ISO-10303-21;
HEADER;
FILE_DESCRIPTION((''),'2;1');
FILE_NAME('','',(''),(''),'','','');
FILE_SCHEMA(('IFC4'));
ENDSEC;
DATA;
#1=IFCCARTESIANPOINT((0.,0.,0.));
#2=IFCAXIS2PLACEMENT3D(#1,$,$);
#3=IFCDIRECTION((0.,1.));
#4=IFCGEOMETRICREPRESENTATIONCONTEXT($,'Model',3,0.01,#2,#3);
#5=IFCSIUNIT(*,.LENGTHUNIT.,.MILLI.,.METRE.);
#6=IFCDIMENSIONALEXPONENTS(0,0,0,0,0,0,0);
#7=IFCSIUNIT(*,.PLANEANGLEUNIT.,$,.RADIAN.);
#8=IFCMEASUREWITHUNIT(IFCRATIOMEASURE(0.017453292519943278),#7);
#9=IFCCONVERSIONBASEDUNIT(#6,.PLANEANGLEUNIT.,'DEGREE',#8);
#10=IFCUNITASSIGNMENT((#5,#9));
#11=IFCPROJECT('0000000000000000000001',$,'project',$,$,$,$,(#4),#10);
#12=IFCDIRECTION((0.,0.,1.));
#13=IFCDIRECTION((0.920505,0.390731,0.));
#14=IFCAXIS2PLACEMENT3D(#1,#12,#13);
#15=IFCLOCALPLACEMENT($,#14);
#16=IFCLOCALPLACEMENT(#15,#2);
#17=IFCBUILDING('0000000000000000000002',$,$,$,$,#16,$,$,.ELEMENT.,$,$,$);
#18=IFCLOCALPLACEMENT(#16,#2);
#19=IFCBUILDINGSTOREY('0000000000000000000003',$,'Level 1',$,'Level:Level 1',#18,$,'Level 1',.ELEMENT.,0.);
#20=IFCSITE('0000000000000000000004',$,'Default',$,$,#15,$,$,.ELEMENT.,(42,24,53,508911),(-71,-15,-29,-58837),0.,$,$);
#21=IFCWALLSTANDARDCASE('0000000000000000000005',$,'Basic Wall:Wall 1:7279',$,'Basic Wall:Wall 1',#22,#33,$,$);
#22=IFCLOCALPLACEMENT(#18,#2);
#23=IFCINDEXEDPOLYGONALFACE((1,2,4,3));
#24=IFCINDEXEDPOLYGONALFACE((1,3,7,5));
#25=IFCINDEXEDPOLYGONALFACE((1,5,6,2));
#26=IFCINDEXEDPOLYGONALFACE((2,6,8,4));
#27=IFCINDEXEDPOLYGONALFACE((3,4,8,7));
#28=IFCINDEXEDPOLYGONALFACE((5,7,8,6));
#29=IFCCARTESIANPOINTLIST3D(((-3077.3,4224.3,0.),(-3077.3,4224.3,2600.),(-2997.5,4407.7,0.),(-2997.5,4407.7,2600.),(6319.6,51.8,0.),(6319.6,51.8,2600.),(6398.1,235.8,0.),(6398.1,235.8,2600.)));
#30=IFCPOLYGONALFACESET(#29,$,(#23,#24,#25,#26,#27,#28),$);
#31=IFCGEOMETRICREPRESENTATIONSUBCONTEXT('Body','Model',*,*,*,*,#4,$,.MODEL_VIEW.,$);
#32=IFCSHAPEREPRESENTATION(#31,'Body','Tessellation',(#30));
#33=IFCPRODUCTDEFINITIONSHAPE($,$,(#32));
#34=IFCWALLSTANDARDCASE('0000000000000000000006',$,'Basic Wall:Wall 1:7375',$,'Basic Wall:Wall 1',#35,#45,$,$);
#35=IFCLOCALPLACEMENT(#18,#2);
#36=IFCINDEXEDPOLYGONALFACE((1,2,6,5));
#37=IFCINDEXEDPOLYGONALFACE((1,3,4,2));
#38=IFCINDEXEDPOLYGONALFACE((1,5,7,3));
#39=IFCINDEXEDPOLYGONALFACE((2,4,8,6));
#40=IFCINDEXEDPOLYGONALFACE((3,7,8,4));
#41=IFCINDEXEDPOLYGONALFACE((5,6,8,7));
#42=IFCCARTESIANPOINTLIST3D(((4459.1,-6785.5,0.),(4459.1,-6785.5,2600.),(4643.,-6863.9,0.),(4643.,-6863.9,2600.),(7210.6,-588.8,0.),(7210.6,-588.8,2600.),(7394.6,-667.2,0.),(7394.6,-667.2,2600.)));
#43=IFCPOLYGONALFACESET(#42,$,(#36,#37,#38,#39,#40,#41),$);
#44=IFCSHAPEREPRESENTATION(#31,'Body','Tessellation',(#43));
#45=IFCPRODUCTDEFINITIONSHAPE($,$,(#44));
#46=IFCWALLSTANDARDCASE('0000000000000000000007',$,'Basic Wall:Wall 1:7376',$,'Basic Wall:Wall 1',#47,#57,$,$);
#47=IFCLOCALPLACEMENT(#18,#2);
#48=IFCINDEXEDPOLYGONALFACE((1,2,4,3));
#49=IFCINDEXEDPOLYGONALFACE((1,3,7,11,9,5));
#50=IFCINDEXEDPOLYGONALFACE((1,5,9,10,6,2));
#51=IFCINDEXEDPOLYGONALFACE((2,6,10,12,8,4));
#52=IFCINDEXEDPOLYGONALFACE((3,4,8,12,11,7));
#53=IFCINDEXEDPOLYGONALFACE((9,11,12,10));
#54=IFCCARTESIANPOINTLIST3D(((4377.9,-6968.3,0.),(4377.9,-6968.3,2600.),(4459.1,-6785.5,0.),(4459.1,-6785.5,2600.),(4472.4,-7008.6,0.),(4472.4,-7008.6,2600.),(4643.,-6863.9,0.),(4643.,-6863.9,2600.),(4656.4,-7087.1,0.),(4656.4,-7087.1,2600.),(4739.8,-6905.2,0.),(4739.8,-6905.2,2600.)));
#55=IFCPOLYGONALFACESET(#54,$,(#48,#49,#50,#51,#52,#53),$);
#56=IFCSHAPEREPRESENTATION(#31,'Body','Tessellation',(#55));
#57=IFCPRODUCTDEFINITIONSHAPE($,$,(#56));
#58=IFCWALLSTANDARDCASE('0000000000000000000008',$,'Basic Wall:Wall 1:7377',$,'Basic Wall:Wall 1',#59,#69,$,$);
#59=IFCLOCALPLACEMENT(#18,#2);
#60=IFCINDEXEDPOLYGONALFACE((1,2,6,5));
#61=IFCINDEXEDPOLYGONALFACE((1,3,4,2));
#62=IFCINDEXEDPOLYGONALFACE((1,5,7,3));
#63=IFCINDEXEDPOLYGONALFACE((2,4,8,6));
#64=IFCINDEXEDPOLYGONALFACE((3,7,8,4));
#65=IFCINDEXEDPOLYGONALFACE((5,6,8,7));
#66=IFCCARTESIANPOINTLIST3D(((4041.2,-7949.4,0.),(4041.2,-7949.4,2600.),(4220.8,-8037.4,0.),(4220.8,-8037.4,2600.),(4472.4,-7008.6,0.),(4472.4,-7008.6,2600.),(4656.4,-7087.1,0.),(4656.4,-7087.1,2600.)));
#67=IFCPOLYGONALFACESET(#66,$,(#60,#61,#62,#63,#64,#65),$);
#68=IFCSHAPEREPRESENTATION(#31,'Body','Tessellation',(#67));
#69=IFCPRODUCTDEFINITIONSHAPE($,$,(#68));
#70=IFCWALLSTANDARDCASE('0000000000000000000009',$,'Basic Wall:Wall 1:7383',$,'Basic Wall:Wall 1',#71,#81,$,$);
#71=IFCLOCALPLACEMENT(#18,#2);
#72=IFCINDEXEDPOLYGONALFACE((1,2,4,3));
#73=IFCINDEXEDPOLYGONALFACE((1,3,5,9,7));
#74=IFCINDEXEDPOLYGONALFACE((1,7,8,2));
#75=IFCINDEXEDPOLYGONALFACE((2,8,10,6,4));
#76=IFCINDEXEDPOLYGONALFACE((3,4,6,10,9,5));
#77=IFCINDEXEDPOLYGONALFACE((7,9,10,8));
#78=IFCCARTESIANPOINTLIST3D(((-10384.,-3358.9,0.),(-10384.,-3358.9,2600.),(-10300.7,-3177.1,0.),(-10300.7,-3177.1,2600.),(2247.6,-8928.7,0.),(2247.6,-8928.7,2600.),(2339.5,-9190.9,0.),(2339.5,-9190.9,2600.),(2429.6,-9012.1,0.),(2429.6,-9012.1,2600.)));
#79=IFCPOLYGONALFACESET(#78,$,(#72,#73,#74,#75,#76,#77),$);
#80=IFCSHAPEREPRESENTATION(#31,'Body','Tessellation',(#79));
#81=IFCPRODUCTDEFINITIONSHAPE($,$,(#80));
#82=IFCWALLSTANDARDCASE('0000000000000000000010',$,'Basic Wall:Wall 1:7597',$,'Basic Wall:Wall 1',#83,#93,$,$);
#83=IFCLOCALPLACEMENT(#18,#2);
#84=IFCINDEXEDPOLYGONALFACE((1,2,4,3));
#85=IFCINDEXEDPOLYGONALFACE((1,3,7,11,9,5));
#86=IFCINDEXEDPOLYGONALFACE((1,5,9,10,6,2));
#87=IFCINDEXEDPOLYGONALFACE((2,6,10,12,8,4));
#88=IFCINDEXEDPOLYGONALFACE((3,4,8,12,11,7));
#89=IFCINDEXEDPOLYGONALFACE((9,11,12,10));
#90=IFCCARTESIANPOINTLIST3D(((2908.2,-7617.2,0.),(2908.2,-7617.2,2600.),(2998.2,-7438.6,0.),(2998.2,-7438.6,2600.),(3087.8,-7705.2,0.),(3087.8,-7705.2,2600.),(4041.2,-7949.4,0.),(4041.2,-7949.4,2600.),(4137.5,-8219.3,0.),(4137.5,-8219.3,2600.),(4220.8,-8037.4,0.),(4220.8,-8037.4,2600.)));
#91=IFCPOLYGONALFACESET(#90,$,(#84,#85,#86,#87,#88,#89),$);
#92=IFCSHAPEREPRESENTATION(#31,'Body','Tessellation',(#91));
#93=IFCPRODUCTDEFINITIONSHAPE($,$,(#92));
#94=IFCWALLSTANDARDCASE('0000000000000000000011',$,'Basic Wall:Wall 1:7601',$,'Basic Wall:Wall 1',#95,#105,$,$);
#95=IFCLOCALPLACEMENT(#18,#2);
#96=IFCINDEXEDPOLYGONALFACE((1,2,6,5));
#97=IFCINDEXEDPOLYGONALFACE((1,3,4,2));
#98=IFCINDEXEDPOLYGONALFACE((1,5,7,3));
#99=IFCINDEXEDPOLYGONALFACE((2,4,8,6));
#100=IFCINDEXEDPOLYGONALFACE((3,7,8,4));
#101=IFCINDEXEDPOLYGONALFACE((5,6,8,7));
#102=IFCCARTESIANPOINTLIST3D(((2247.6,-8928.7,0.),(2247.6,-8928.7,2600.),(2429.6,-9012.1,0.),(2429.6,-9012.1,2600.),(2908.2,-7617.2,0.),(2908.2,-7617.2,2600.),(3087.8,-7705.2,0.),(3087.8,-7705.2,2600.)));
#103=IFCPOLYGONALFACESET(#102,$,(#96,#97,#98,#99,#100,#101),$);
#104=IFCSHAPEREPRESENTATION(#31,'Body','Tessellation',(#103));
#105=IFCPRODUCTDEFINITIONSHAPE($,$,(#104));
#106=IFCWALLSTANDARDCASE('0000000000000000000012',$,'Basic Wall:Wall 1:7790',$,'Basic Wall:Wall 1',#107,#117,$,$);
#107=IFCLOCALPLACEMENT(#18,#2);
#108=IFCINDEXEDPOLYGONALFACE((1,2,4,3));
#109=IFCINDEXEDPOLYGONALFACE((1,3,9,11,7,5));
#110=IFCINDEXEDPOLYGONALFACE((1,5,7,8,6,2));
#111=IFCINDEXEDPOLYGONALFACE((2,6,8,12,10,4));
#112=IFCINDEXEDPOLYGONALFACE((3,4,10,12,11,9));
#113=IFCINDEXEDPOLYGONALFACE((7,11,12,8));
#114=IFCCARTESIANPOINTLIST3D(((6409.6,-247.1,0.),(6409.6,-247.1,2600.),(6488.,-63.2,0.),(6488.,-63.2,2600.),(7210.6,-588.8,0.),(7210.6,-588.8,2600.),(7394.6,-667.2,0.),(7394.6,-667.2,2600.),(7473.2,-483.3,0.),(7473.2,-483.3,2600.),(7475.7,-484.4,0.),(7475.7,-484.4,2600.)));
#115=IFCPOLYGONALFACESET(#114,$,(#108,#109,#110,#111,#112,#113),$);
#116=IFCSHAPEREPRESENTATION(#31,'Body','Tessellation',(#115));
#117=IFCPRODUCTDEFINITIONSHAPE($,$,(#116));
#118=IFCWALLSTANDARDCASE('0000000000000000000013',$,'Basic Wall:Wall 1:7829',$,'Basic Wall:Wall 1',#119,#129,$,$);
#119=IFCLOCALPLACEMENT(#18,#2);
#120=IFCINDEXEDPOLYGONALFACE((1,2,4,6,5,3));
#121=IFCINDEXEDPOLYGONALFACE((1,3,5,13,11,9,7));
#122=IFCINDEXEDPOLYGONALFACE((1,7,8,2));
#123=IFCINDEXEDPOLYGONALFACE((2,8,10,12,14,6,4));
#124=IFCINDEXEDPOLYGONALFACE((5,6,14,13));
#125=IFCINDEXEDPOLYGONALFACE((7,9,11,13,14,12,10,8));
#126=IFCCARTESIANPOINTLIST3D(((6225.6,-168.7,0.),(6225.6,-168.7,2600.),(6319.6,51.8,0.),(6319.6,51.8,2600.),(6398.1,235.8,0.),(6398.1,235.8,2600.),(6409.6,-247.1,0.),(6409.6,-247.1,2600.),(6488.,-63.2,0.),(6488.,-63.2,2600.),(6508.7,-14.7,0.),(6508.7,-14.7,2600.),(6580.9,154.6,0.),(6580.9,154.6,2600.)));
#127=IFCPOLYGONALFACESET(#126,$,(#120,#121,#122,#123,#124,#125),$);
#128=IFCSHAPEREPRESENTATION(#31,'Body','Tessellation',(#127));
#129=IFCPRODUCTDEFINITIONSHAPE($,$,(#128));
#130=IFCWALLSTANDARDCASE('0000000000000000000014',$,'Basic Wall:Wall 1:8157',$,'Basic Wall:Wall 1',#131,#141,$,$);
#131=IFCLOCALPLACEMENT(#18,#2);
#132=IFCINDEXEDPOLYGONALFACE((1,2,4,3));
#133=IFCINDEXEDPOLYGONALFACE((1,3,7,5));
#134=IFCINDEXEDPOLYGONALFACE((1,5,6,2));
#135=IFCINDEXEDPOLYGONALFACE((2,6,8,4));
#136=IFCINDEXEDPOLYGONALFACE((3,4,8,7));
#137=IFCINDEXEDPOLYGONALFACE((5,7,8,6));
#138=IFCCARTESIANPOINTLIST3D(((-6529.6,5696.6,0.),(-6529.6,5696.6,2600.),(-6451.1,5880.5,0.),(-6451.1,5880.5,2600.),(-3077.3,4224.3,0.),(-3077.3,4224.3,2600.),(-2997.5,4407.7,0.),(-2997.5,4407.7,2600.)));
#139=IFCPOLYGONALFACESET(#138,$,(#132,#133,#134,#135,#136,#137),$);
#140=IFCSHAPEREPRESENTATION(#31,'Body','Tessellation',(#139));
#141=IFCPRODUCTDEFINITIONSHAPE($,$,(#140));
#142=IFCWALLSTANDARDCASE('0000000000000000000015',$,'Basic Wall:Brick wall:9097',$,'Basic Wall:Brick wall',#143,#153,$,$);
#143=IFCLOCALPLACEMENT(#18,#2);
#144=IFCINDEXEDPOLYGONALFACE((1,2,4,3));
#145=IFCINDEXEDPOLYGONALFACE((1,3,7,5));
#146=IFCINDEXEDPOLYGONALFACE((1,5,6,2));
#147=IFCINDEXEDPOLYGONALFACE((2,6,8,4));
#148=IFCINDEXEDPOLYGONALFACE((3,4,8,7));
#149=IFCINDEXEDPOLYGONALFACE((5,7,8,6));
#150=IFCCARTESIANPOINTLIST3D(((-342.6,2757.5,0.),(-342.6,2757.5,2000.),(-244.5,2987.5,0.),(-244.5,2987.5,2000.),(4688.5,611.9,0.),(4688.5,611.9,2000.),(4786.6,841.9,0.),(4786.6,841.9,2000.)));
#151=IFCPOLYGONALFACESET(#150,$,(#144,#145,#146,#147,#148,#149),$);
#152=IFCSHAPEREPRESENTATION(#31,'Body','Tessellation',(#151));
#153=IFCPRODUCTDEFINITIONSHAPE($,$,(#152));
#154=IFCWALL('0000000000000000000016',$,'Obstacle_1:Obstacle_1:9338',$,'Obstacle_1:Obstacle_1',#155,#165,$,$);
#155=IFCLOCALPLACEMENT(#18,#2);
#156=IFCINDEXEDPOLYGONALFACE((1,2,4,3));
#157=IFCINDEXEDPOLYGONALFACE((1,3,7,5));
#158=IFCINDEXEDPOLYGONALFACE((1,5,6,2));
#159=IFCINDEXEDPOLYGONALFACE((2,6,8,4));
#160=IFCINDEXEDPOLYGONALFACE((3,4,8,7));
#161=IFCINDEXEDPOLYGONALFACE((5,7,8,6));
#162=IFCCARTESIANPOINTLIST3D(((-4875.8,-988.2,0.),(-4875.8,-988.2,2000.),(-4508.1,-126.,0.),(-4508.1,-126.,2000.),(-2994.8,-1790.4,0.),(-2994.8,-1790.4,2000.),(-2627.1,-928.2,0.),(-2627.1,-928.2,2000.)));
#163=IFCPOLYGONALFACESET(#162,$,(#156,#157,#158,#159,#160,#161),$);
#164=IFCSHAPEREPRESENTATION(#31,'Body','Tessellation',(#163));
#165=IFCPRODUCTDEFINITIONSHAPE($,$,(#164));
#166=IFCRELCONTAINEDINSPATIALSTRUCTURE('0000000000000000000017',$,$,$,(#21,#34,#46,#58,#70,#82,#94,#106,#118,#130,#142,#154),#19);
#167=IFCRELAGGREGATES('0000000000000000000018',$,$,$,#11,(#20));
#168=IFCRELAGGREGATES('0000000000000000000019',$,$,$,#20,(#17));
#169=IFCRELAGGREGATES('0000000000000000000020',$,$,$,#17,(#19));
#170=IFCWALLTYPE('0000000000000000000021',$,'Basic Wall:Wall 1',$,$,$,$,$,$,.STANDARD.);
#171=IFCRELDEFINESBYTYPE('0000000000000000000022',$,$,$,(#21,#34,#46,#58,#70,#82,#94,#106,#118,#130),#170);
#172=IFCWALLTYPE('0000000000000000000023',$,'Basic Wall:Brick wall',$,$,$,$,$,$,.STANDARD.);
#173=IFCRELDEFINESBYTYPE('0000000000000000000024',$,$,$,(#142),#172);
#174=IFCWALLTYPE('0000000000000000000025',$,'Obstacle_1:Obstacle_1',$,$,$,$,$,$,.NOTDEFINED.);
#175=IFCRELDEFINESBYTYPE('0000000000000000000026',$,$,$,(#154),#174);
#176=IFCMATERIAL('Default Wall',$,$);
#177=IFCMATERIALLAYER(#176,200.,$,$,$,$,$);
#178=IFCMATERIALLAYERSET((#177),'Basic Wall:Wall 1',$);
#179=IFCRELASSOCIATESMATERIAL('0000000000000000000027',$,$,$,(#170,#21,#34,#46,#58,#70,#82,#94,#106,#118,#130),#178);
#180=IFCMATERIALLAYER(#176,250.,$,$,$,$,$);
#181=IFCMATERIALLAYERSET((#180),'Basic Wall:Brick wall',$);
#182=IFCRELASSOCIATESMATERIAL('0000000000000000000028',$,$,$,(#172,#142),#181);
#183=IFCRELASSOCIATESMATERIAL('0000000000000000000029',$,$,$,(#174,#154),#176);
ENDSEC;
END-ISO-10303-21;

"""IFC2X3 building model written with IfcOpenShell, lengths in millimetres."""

from ifc_helpers import new_model, entity, si_unit, converted_unit, direction, frame, frame_2d, origin, place, context, subcontext, project, spatial, polyline, rectangle, outline, extrude, material, layer, layer_set, layer_usage, type_object, element, save


model = new_model("IFC2X3")

# Units and contexts
model_context = context("Model", 3, precision=0.01, world=origin(), true_north=direction((0.0, 1.0)))
body_context = subcontext(model_context, "Body", "Model", "MODEL_VIEW")
ifc_project = project(units=[si_unit("LENGTHUNIT", "METRE", prefix="MILLI"), converted_unit("PLANEANGLEUNIT", "DEGREE", entity("IfcRatioMeasure", 0.017453292519943278), si_unit("PLANEANGLEUNIT", "RADIAN"), dimensions=[0, 0, 0, 0, 0, 0, 0])], contexts=[model_context])

# Site, building, storey
site_placement = place(None, frame((0.0, 0.0, 0.0), z_axis=(0.0, 0.0, 1.0), x_axis=(0.920505, 0.390731, 0.0)))
site = spatial("IfcSite", under=ifc_project, at=site_placement, Name="Default", CompositionType="ELEMENT", RefLatitude=(42, 24, 53, 508911), RefLongitude=(-71, -15, -29, -58837), RefElevation=0.0)
building_placement = place(site_placement, origin())
building = spatial("IfcBuilding", under=site, at=building_placement, CompositionType="ELEMENT")
storey_placement = place(building_placement, origin())
storey = spatial("IfcBuildingStorey", under=building, at=storey_placement, Name="Level 1", ObjectType="Level:Level 1", LongName="Level 1", CompositionType="ELEMENT", Elevation=0.0)

# Walls
ifc_material_1 = material(Name="Default Wall")
ifc_layer_1 = layer(ifc_material_1, 200.0)
ifc_layer_set_1 = layer_set([ifc_layer_1], Name="Basic Wall:Wall 1")
ifc_layer_usage_1 = layer_usage(ifc_layer_set_1, "AXIS2", "NEGATIVE", 100.0)
wall_type_1 = type_object("IfcWallType", Name="Basic Wall:Wall 1", PredefinedType="STANDARD", material=ifc_layer_set_1)
wall_1_placement = place(storey_placement, frame((-3038.1, 4316.3, 0.0), z_axis=(0.0, 0.0, 1.0), x_axis=(0.913952, -0.405822, 0.0)))
element("IfcWallStandardCase", 1, at=wall_1_placement, inside=storey, type_object=wall_type_1, material=ifc_layer_usage_1, Name="Basic Wall:Wall 1:7279", ObjectType="Basic Wall:Wall 1", context=body_context, shape_type="SweptSolid", body=[
    extrude(outline(polyline([(10283.1, -100.0), (10280.2, 100.0), (0.0, 100.0), (1.5, -100.0), (10283.1, -100.0)])), origin(), (0.0, 0.0, 1.0), 2600.0),
])
ifc_layer_usage_2 = layer_usage(ifc_layer_set_1, "AXIS2", "NEGATIVE", 100.0)
wall_2_placement = place(storey_placement, frame((7303.2, -626.6, 0.0), z_axis=(0.0, 0.0, 1.0), x_axis=(-0.405822, -0.913952, 0.0)))
element("IfcWallStandardCase", 2, at=wall_2_placement, inside=storey, type_object=wall_type_1, material=ifc_layer_usage_2, Name="Basic Wall:Wall 1:7375", ObjectType="Basic Wall:Wall 1", context=body_context, shape_type="SweptSolid", body=[
    extrude(outline(polyline([(6783.1, -100.0), (6780.1, 100.0), (0.0, 100.0), (3.0, -100.0), (6783.1, -100.0)])), origin(), (0.0, 0.0, 1.0), 2600.0),
])
ifc_layer_usage_3 = layer_usage(ifc_layer_set_1, "AXIS2", "NEGATIVE", 100.0)
wall_3_placement = place(storey_placement, frame((4417.1, -6876.3, 0.0), z_axis=(0.0, 0.0, 1.0), x_axis=(0.919844, -0.392284, 0.0)))
element("IfcWallStandardCase", 3, at=wall_3_placement, inside=storey, type_object=wall_type_1, material=ifc_layer_usage_3, Name="Basic Wall:Wall 1:7376", ObjectType="Basic Wall:Wall 1", context=body_context, shape_type="SweptSolid", body=[
    extrude(outline(polyline([(302.8, -100.0), (308.2, 100.0), (203.0, 100.0), (3.0, 100.0), (0.0, -100.0), (102.7, -100.0), (302.8, -100.0)])), origin(), (0.0, 0.0, 1.0), 2600.0),
])
ifc_layer_usage_4 = layer_usage(ifc_layer_set_1, "AXIS2", "NEGATIVE", 100.0)
wall_4_placement = place(storey_placement, frame((4565.5, -7045.4, 0.0), z_axis=(0.0, 0.0, 1.0), x_axis=(-0.416671, -0.909057, 0.0)))
element("IfcWallStandardCase", 4, at=wall_4_placement, inside=storey, type_object=wall_type_1, material=ifc_layer_usage_4, Name="Basic Wall:Wall 1:7377", ObjectType="Basic Wall:Wall 1", context=body_context, shape_type="SweptSolid", body=[
    extrude(outline(polyline([(1040.3, -100.0), (1045.5, 100.0), (0.0, 100.0), (5.3, -100.0), (1040.3, -100.0)])), origin(), (0.0, 0.0, 1.0), 2600.0),
])
ifc_layer_usage_5 = layer_usage(ifc_layer_set_1, "AXIS2", "NEGATIVE", 100.0)
wall_5_placement = place(storey_placement, frame((2387.9, -9103.0, 0.0), z_axis=(0.0, 0.0, 1.0), x_axis=(-0.909057, 0.416672, 0.0)))
element("IfcWallStandardCase", 5, at=wall_5_placement, inside=storey, type_object=wall_type_1, material=ifc_layer_usage_5, Name="Basic Wall:Wall 1:7383", ObjectType="Basic Wall:Wall 1", context=body_context, shape_type="SweptSolid", body=[
    extrude(outline(polyline([(14003.8, -100.0), (14003.8, 100.0), (7.4, 100.0), (0.0, -100.0), (200.1, -100.0), (14003.8, -100.0)])), origin(), (0.0, 0.0, 1.0), 2600.0),
])
ifc_layer_usage_6 = layer_usage(ifc_layer_set_1, "AXIS2", "NEGATIVE", 100.0)
wall_6_placement = place(storey_placement, frame((4181.4, -8129.5, 0.0), z_axis=(0.0, 0.0, 1.0), x_axis=(-0.898053, 0.439887, 0.0)))
element("IfcWallStandardCase", 6, at=wall_6_placement, inside=storey, type_object=wall_type_1, material=ifc_layer_usage_6, Name="Basic Wall:Wall 1:7597", ObjectType="Basic Wall:Wall 1", context=body_context, shape_type="SweptSolid", body=[
    extrude(outline(polyline([(1366.6, -100.0), (1368.8, 100.0), (1168.8, 100.0), (0.0, 100.0), (5.1, -100.0), (205.2, -100.0), (1366.6, -100.0)])), origin(), (0.0, 0.0, 1.0), 2600.0),
])
ifc_layer_usage_7 = layer_usage(ifc_layer_set_1, "AXIS2", "NEGATIVE", 100.0)
wall_7_placement = place(storey_placement, frame((2998.5, -7660.2, 0.0), z_axis=(0.0, 0.0, 1.0), x_axis=(-0.449838, -0.89311, 0.0)))
element("IfcWallStandardCase", 7, at=wall_7_placement, inside=storey, type_object=wall_type_1, material=ifc_layer_usage_7, Name="Basic Wall:Wall 1:7601", ObjectType="Basic Wall:Wall 1", context=body_context, shape_type="SweptSolid", body=[
    extrude(outline(polyline([(1470.7, -100.0), (1463.4, 100.0), (0.0, 100.0), (2.2, -100.0), (1470.7, -100.0)])), origin(), (0.0, 0.0, 1.0), 2600.0),
])
ifc_layer_usage_8 = layer_usage(ifc_layer_set_1, "AXIS2", "POSITIVE", -100.0)
wall_8_placement = place(storey_placement, frame((7436.5, -576.4, 0.0), z_axis=(0.0, 0.0, 1.0), x_axis=(-0.919844, 0.392284, 0.0)))
element("IfcWallStandardCase", 8, at=wall_8_placement, inside=storey, type_object=wall_type_1, material=ifc_layer_usage_8, Name="Basic Wall:Wall 1:7790", ObjectType="Basic Wall:Wall 1", context=body_context, shape_type="SweptSolid", body=[
    extrude(outline(polyline([(1073.8, -100.0), (1073.8, 100.0), (203.0, 100.0), (3.0, 100.0), (0.0, -100.0), (2.7, -100.0), (1073.8, -100.0)])), origin(), (0.0, 0.0, 1.0), 2600.0),
])
ifc_layer_usage_9 = layer_usage(ifc_layer_set_1, "AXIS2", "POSITIVE", -100.0)
wall_9_placement = place(storey_placement, frame((6317.6, -207.9, 0.0), z_axis=(0.0, 0.0, 1.0), x_axis=(0.392284, 0.919844, 0.0)))
element("IfcWallStandardCase", 9, at=wall_9_placement, inside=storey, type_object=wall_type_1, material=ifc_layer_usage_9, Name="Basic Wall:Wall 1:7829", ObjectType="Basic Wall:Wall 1", context=body_context, shape_type="SweptSolid", body=[
    extrude(outline(polyline([(436.7, -100.0), (439.7, 100.0), (239.7, 100.0), (0.0, 100.0), (0.0, -100.0), (200.0, -100.0), (252.7, -100.0), (436.7, -100.0)])), origin(), (0.0, 0.0, 1.0), 2600.0),
])
ifc_layer_usage_10 = layer_usage(ifc_layer_set_1, "AXIS2", "NEGATIVE", 100.0)
wall_10_placement = place(storey_placement, frame((-6490.4, 5788.5, 0.0), z_axis=(0.0, 0.0, 1.0), x_axis=(0.919844, -0.392284, 0.0)))
element("IfcWallStandardCase", 10, at=wall_10_placement, inside=storey, type_object=wall_type_1, material=ifc_layer_usage_10, Name="Basic Wall:Wall 1:8157", ObjectType="Basic Wall:Wall 1", context=body_context, shape_type="SweptSolid", body=[
    extrude(outline(polyline([(3753.1, -100.0), (3754.6, 100.0), (0.0, 100.0), (0.0, -100.0), (3753.1, -100.0)])), origin(), (0.0, 0.0, 1.0), 2600.0),
])
ifc_layer_2 = layer(ifc_material_1, 250.0)
ifc_layer_set_2 = layer_set([ifc_layer_2], Name="Basic Wall:Brick wall")
ifc_layer_usage_11 = layer_usage(ifc_layer_set_2, "AXIS2", "NEGATIVE", 125.0)
wall_type_2 = type_object("IfcWallType", Name="Basic Wall:Brick wall", PredefinedType="STANDARD", material=ifc_layer_set_2)
wall_11_placement = place(storey_placement, frame((-293.6, 2872.5, 0.0), z_axis=(0.0, 0.0, 1.0), x_axis=(0.919844, -0.392284, 0.0)))
element("IfcWallStandardCase", 11, at=wall_11_placement, inside=storey, type_object=wall_type_2, material=ifc_layer_usage_11, Name="Basic Wall:Brick wall:9097", ObjectType="Basic Wall:Brick wall", context=body_context, shape_type="SweptSolid", body=[
    extrude(rectangle(XDim=5469.5, YDim=250.0, at=frame_2d((2734.8, 0.0), x_axis=(-1.0, 0.0))), origin(), (0.0, 0.0, 1.0), 2000.0),
])
wall_type_3 = type_object("IfcWallType", Name="Obstacle_1:Obstacle_1", PredefinedType="NOTDEFINED", material=ifc_material_1)
wall_12_placement = place(storey_placement, frame((-4875.8, -988.2, 0.0), z_axis=(0.0, 0.0, 1.0), x_axis=(0.919844, -0.392284, 0.0)))
element("IfcWall", 12, at=wall_12_placement, inside=storey, type_object=wall_type_3, material=ifc_material_1, Name="Obstacle_1:Obstacle_1:9338", ObjectType="Obstacle_1:Obstacle_1", context=body_context, shape_type="SweptSolid", body=[
    extrude(rectangle(XDim=2044.9, YDim=937.3, at=frame_2d((0.0, 0.0), x_axis=(1.0, 0.0))), frame((1022.5, 468.7, 0.0), z_axis=(0.0, 0.0, 1.0), x_axis=(-1.0, 0.0, 0.0)), (0.0, 0.0, 1.0), 2000.0),
])

save(model, "model.ifc")
